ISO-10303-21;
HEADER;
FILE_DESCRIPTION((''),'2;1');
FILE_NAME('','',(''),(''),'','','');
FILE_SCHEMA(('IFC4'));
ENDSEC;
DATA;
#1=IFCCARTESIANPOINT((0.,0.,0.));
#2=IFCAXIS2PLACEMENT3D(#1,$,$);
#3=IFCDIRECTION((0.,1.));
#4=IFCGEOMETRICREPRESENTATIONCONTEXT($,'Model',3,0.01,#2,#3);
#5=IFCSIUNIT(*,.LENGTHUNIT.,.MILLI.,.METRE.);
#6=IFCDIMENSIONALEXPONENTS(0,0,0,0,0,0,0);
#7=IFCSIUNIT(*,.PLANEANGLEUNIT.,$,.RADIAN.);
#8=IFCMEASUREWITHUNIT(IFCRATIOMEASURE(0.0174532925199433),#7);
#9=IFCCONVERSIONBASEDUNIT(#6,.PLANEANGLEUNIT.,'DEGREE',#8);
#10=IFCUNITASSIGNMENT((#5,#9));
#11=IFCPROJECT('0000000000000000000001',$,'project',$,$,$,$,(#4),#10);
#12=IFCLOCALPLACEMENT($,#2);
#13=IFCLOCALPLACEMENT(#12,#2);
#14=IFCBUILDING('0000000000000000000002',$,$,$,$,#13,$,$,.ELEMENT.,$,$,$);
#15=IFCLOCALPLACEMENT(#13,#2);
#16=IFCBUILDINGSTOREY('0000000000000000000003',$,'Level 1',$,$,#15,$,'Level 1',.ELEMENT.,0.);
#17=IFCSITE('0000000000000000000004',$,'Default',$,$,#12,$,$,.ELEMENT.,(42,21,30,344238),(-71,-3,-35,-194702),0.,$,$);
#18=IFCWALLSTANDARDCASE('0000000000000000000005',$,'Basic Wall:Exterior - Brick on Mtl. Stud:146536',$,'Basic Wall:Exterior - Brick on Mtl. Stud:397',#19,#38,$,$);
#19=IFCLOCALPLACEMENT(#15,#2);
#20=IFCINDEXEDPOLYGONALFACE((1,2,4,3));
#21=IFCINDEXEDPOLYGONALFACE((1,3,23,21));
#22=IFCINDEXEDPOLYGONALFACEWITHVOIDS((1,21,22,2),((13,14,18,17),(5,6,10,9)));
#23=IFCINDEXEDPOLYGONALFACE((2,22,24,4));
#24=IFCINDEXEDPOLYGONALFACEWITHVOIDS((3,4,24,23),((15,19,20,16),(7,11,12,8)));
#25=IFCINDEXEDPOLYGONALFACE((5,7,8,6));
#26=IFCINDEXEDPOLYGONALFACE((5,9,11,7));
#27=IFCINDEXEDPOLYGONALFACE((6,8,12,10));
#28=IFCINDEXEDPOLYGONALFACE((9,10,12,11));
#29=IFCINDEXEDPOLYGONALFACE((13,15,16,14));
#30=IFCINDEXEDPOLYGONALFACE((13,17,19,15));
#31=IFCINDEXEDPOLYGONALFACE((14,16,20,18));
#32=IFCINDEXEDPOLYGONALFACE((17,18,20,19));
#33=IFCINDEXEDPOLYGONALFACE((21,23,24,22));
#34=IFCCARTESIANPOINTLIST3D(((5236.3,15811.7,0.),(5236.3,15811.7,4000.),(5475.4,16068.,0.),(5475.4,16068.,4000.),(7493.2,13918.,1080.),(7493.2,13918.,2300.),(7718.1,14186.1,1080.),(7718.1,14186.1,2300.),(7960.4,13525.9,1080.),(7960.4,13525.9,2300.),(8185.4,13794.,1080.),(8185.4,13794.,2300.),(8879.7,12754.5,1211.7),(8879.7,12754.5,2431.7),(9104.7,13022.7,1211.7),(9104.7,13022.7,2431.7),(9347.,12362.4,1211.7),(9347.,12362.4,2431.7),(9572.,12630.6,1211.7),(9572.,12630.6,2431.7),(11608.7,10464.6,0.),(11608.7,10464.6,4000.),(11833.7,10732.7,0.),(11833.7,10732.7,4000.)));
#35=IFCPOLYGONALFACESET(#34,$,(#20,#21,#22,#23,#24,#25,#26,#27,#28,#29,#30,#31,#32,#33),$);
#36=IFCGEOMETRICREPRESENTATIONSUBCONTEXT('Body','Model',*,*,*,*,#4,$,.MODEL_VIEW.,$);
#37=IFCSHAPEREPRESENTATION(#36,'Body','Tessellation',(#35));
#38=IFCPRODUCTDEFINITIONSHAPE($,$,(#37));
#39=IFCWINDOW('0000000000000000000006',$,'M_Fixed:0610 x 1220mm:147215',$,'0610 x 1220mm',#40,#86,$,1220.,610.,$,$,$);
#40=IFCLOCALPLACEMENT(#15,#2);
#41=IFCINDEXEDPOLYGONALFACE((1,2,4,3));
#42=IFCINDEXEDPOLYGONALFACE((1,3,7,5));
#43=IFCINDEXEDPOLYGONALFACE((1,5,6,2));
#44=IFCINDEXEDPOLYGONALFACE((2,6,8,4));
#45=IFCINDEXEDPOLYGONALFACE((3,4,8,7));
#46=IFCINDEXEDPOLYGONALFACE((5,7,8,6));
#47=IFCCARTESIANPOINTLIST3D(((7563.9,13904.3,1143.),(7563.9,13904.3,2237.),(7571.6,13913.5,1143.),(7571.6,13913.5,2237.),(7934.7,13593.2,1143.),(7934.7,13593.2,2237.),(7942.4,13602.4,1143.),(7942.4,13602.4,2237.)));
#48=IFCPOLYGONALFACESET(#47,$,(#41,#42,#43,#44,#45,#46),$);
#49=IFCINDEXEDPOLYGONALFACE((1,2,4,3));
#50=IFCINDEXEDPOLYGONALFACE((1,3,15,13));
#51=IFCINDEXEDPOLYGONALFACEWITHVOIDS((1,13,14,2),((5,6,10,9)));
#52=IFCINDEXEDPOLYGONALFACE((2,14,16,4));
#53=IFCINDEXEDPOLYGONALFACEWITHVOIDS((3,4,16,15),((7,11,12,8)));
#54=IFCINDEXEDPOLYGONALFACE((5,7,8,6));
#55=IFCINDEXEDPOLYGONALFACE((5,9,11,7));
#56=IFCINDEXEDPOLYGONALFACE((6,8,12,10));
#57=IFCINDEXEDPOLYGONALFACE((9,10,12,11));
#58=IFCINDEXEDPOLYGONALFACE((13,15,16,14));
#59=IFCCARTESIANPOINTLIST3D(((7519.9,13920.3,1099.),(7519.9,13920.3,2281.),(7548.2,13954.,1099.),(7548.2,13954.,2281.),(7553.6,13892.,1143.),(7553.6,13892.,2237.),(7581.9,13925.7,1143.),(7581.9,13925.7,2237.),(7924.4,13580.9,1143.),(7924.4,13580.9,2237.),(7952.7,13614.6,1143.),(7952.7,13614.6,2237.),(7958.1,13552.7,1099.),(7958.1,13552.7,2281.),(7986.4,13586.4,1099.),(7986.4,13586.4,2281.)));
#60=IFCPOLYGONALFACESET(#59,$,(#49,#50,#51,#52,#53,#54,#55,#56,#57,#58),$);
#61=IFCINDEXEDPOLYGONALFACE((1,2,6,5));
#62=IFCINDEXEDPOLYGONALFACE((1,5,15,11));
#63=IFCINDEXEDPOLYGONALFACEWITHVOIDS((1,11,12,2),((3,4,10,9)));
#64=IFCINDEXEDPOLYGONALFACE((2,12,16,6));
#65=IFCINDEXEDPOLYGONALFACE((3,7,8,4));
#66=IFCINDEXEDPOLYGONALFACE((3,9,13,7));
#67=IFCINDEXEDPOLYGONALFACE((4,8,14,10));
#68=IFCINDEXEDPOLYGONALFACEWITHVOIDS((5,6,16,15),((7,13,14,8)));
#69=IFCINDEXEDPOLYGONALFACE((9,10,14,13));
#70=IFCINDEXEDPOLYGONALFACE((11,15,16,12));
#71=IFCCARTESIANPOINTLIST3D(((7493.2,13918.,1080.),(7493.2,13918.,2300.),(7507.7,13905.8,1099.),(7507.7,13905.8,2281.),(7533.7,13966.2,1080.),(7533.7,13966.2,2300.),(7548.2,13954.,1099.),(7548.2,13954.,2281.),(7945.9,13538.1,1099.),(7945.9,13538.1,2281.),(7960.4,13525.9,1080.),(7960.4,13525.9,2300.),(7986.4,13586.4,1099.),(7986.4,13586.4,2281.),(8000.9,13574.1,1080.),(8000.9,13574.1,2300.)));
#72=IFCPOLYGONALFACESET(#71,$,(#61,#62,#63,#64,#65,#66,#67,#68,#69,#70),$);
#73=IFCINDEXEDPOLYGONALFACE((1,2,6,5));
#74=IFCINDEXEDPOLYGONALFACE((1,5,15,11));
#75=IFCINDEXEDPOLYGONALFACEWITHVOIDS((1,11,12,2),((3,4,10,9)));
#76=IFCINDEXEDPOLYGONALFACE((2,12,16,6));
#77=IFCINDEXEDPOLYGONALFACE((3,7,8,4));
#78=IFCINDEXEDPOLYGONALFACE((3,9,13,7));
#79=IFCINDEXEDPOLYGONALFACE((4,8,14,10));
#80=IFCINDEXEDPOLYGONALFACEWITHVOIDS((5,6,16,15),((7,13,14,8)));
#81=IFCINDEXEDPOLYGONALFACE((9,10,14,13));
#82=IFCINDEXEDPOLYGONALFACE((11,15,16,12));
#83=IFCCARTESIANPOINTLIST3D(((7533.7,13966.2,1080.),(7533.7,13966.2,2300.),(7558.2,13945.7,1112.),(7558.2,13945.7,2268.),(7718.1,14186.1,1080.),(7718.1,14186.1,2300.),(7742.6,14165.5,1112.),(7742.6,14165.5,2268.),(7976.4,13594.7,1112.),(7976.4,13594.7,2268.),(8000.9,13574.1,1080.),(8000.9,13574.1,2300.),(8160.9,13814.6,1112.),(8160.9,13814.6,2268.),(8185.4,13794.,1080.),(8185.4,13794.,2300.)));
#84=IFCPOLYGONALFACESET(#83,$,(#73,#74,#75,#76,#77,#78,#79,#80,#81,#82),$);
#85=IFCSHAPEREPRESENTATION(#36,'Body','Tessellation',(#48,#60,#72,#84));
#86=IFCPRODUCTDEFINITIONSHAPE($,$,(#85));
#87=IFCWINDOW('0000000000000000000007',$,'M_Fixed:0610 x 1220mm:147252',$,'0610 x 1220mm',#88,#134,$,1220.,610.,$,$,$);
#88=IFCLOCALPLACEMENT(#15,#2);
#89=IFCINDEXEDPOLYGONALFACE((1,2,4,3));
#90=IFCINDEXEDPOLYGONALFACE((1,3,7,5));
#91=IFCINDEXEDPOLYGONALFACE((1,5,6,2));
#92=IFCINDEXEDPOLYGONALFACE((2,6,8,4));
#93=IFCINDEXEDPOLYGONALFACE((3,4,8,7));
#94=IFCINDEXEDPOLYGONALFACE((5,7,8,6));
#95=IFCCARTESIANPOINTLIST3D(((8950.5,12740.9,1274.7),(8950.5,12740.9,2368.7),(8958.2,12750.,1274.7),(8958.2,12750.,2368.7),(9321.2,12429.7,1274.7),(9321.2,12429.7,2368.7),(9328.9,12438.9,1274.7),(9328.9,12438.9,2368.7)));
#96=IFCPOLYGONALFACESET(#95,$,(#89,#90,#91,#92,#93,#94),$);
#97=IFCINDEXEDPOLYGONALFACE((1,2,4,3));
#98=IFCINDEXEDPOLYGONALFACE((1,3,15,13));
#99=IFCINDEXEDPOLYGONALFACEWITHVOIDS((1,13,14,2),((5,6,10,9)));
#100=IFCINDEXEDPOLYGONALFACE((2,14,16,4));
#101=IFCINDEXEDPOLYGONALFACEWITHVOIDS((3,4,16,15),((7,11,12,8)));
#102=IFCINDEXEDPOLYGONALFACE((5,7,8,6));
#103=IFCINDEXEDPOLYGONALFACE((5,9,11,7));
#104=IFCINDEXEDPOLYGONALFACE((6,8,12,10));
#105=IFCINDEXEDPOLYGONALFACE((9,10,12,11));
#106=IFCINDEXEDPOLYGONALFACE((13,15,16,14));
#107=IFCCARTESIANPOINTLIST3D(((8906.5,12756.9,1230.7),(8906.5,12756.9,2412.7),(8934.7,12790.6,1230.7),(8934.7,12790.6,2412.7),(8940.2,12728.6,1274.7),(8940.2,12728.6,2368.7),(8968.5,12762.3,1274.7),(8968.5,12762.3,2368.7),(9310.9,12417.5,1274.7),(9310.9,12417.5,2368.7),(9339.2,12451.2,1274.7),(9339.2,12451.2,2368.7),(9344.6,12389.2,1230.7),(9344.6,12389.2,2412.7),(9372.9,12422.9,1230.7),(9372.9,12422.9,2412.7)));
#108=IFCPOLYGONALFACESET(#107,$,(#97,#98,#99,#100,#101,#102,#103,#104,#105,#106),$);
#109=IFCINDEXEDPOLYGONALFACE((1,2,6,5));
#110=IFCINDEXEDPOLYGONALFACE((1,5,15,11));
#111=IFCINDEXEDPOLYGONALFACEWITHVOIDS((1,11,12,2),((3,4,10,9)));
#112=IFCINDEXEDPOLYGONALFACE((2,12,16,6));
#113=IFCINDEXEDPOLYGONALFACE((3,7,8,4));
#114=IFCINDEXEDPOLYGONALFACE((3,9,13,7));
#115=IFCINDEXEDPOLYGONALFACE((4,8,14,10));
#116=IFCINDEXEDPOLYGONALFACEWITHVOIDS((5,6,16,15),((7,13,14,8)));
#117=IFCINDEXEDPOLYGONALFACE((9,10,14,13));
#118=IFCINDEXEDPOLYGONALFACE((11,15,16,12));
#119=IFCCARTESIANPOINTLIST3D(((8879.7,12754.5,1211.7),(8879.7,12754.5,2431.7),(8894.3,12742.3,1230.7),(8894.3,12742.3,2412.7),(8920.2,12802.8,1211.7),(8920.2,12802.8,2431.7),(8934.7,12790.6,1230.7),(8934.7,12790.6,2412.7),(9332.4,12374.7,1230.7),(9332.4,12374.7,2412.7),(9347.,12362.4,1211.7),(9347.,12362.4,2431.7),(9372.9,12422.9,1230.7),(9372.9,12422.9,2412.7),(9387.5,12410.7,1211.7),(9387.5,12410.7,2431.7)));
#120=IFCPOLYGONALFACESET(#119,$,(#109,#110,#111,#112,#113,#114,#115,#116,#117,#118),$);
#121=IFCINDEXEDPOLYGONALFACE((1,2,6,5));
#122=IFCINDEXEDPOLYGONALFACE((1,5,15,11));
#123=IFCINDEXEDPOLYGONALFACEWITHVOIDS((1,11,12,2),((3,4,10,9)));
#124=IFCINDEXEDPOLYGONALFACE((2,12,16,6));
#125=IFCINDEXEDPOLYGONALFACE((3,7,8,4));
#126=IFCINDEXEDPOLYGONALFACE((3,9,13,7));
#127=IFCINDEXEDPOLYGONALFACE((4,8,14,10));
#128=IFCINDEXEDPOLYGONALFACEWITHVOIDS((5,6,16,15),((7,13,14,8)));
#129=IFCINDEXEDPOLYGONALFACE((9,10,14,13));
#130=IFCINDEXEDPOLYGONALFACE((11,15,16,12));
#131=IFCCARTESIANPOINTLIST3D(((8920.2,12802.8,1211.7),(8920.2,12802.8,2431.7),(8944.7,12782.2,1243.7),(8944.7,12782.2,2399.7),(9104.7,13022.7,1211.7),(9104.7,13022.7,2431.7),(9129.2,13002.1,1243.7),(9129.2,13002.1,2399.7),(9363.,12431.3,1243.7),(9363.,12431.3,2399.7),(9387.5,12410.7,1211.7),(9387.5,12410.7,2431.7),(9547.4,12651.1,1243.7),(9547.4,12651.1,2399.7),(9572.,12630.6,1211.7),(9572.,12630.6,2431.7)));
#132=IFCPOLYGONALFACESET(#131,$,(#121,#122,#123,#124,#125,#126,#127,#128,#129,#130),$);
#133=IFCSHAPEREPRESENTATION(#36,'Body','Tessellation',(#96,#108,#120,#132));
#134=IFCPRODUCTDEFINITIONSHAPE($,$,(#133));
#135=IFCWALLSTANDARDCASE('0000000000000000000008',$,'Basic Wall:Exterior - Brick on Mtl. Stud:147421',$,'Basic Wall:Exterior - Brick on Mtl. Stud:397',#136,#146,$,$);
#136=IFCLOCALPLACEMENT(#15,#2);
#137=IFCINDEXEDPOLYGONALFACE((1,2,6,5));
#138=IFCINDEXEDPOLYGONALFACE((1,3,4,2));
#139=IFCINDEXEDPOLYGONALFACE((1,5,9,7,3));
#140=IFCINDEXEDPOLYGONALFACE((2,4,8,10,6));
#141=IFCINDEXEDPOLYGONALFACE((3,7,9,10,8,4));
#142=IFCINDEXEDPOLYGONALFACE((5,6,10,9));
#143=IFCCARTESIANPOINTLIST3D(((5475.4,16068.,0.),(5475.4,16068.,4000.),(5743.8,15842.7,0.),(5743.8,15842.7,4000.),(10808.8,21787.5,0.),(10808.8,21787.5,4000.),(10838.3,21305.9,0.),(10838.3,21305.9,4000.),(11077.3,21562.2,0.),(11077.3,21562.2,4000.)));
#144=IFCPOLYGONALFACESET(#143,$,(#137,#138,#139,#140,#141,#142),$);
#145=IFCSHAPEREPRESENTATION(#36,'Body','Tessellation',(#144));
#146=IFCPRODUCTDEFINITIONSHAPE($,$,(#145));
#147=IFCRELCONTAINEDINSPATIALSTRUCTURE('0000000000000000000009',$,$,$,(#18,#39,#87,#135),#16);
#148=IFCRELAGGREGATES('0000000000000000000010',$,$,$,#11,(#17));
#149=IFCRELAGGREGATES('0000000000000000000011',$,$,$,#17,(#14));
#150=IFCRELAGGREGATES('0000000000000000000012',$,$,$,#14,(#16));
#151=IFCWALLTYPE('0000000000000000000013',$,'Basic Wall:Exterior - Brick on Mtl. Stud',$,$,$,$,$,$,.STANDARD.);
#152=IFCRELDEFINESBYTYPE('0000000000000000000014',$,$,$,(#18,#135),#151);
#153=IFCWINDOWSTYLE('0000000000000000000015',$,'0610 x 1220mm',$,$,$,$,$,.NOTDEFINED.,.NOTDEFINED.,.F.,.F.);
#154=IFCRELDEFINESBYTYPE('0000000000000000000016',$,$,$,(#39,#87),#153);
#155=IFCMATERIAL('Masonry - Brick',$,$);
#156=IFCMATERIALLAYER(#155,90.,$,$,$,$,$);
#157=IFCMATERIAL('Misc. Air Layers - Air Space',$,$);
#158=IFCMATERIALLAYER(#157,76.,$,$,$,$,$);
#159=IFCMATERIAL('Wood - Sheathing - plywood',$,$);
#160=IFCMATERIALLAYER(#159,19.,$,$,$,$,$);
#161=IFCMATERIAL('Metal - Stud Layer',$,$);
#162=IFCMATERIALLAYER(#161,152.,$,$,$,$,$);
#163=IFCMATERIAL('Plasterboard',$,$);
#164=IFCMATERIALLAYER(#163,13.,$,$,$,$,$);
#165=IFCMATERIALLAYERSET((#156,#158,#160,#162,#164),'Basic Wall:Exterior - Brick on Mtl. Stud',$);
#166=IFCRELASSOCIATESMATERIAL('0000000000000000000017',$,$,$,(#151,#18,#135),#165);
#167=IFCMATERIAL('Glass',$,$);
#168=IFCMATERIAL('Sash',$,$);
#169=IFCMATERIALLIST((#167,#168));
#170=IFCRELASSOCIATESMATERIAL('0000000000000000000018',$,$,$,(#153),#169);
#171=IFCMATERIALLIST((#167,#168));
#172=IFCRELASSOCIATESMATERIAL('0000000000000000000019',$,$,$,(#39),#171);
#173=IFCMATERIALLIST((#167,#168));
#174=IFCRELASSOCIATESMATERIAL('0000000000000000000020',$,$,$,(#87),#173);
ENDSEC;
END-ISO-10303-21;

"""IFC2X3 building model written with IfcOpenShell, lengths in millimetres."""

from ifc_helpers import new_model, entity, si_unit, converted_unit, direction, frame, frame_2d, origin, place, context, subcontext, project, spatial, polyline, rectangle, outline, extrude, source, transform, mapped, material, material_list, layer, layer_set, layer_usage, type_object, type_shapes, element, fill, save


model = new_model("IFC2X3")

# Units and contexts
model_context = context("Model", 3, precision=0.01, world=origin(), true_north=direction((0.0, 1.0)))
body_context = subcontext(model_context, "Body", "Model", "MODEL_VIEW")
ifc_project = project(units=[si_unit("LENGTHUNIT", "METRE", prefix="MILLI"), converted_unit("PLANEANGLEUNIT", "DEGREE", entity("IfcRatioMeasure", 0.0174532925199433), si_unit("PLANEANGLEUNIT", "RADIAN"), dimensions=[0, 0, 0, 0, 0, 0, 0])], contexts=[model_context])

# Site, building, storey
site_placement = place(None, origin())
site = spatial("IfcSite", under=ifc_project, at=site_placement, Name="Default", CompositionType="ELEMENT", RefLatitude=(42, 21, 30, 344238), RefLongitude=(-71, -3, -35, -194702), RefElevation=0.0)
building_placement = place(site_placement, origin())
building = spatial("IfcBuilding", under=site, at=building_placement, CompositionType="ELEMENT")
storey_placement = place(building_placement, origin())
storey = spatial("IfcBuildingStorey", under=building, at=storey_placement, Name="Level 1", LongName="Level 1", CompositionType="ELEMENT", Elevation=0.0)

# Shared definitions
ifc_material_1 = material(Name="Masonry - Brick")
ifc_layer_1 = layer(ifc_material_1, 90.0)
ifc_material_2 = material(Name="Misc. Air Layers - Air Space")
ifc_layer_2 = layer(ifc_material_2, 76.0)
ifc_material_3 = material(Name="Wood - Sheathing - plywood")
ifc_layer_3 = layer(ifc_material_3, 19.0)
ifc_material_4 = material(Name="Metal - Stud Layer")
ifc_layer_4 = layer(ifc_material_4, 152.0)
ifc_material_5 = material(Name="Plasterboard")
ifc_layer_5 = layer(ifc_material_5, 13.0)
ifc_layer_set = layer_set([ifc_layer_1, ifc_layer_2, ifc_layer_3, ifc_layer_4, ifc_layer_5], Name="Basic Wall:Exterior - Brick on Mtl. Stud")
wall_type = type_object("IfcWallType", Name="Basic Wall:Exterior - Brick on Mtl. Stud", PredefinedType="STANDARD", material=ifc_layer_set)

# Wall, openings, windows
ifc_layer_usage_1 = layer_usage(ifc_layer_set, "AXIS2", "NEGATIVE", 175.0)
wall_1_placement = place(storey_placement, frame((11721.2, 10598.7, 0.0), z_axis=(0.0, 0.0, 1.0), x_axis=(-0.766044, 0.642788, 0.0)))
wall_1 = element("IfcWallStandardCase", 1, at=wall_1_placement, inside=storey, type_object=wall_type, material=ifc_layer_usage_1, Name="Basic Wall:Exterior - Brick on Mtl. Stud:146536", ObjectType="Basic Wall:Exterior - Brick on Mtl. Stud:397", context=body_context, shape_type="SweptSolid", body=[
    extrude(outline(polyline([(8300.2, -175.0), (8318.6, 175.0), (0.0, 175.0), (0.0, -175.0), (7949.8, -175.0), (8300.2, -175.0)])), origin(), (0.0, 0.0, 1.0), 4000.0),
])
opening_1_placement = place(wall_1_placement, frame((4762.5, -175.0, 1080.0)))
opening_1 = element("IfcOpeningElement", 2, at=opening_1_placement, cuts=wall_1, ObjectType="Opening", context=body_context, shape_type="SweptSolid", body=[
    extrude(rectangle(XDim=1220.0, YDim=610.0, at=frame_2d((610.0, 305.0), x_axis=(1.0, 0.0))), frame((0.0, 0.0, 0.0), z_axis=(0.0, 1.0, 0.0), x_axis=(0.0, 0.0, 1.0)), (0.0, 0.0, 1.0), 350.0),
])
opening_2_placement = place(wall_1_placement, frame((2952.5, -175.0, 1211.7)))
opening_2 = element("IfcOpeningElement", 3, at=opening_2_placement, cuts=wall_1, ObjectType="Opening", context=body_context, shape_type="SweptSolid", body=[
    extrude(rectangle(XDim=1220.0, YDim=610.0, at=frame_2d((610.0, 305.0), x_axis=(1.0, 0.0))), frame((0.0, 0.0, 0.0), z_axis=(0.0, 1.0, 0.0), x_axis=(0.0, 0.0, 1.0)), (0.0, 0.0, 1.0), 350.0),
])
ifc_material_6 = material(Name="Glass")
ifc_material_7 = material(Name="Sash")
ifc_material_list_1 = material_list([ifc_material_6, ifc_material_7])
ifc_material_list_2 = material_list([ifc_material_6, ifc_material_7])
window_style = type_object("IfcWindowStyle", Name="0610 x 1220mm", ConstructionType="NOTDEFINED", OperationType="NOTDEFINED", ParameterTakesPrecedence=False, Sizeable=False, material=ifc_material_list_2)
shared_shape_1 = source(origin(), body_context, "Body", "SweptSolid", [
    extrude(rectangle(XDim=12.0, YDim=484.0, at=frame_2d((0.0, 0.0), x_axis=(1.0, 0.0))), frame((305.0, 309.0, 63.0), z_axis=(0.0, 0.0, 1.0), x_axis=(0.0, -1.0, 0.0)), (0.0, 0.0, 1.0), 1094.0),
    extrude(outline(polyline([(-286.0, -591.0), (286.0, -591.0), (286.0, 591.0), (-286.0, 591.0), (-286.0, -591.0)]), holes=[polyline([(-242.0, -547.0), (-242.0, 547.0), (242.0, 547.0), (242.0, -547.0), (-242.0, -547.0)])]), frame((305.0, 287.0, 610.0), z_axis=(0.0, 1.0, 0.0), x_axis=(1.0, 0.0, 0.0)), (0.0, 0.0, 1.0), 44.0),
    extrude(outline(polyline([(-305.0, -610.0), (305.0, -610.0), (305.0, 610.0), (-305.0, 610.0), (-305.0, -610.0)]), holes=[polyline([(-286.0, -591.0), (-286.0, 591.0), (286.0, 591.0), (286.0, -591.0), (-286.0, -591.0)])]), frame((305.0, 287.0, 610.0), z_axis=(0.0, 1.0, 0.0), x_axis=(1.0, 0.0, 0.0)), (0.0, 0.0, 1.0), 63.0),
    extrude(outline(polyline([(-305.0, -610.0), (305.0, -610.0), (305.0, 610.0), (-305.0, 610.0), (-305.0, -610.0)]), holes=[polyline([(-273.0, -578.0), (-273.0, 578.0), (273.0, 578.0), (273.0, -578.0), (-273.0, -578.0)])]), frame((305.0, 0.0, 610.0), z_axis=(0.0, 1.0, 0.0), x_axis=(1.0, 0.0, 0.0)), (0.0, 0.0, 1.0), 287.0),
])
type_shapes(window_style, [shared_shape_1])
window_1_placement = place(opening_1_placement, origin())
window_1 = element("IfcWindow", 4, at=window_1_placement, inside=storey, type_object=window_style, material=ifc_material_list_1, Name="M_Fixed:0610 x 1220mm:147215", ObjectType="0610 x 1220mm", OverallHeight=1220.0, OverallWidth=610.0, context=body_context, shape_type="MappedRepresentation", body=[
    mapped(shared_shape_1, transform((0.0, 0.0, 0.0), scale=1.0)),
])
fill(opening_1, window_1)
ifc_material_list_3 = material_list([ifc_material_6, ifc_material_7])
window_2_placement = place(opening_2_placement, origin())
window_2 = element("IfcWindow", 5, at=window_2_placement, inside=storey, type_object=window_style, material=ifc_material_list_3, Name="M_Fixed:0610 x 1220mm:147252", ObjectType="0610 x 1220mm", OverallHeight=1220.0, OverallWidth=610.0, context=body_context, shape_type="MappedRepresentation", body=[
    mapped(shared_shape_1, transform((0.0, 0.0, 0.0), scale=1.0)),
])
fill(opening_2, window_2)

# Wall
ifc_layer_usage_2 = layer_usage(ifc_layer_set, "AXIS2", "NEGATIVE", 175.0)
wall_2_placement = place(storey_placement, frame((5603.3, 15948.7, 0.0), z_axis=(0.0, 0.0, 1.0), x_axis=(0.681998, 0.731354, 0.0)))
element("IfcWallStandardCase", 6, at=wall_2_placement, inside=storey, type_object=wall_type, material=ifc_layer_usage_2, Name="Basic Wall:Exterior - Brick on Mtl. Stud:147421", ObjectType="Basic Wall:Exterior - Brick on Mtl. Stud:397", context=body_context, shape_type="SweptSolid", body=[
    extrude(outline(polyline([(7838.7, -175.0), (7820.4, 175.0), (0.0, 175.0), (18.3, -175.0), (7488.2, -175.0), (7838.7, -175.0)])), origin(), (0.0, 0.0, 1.0), 4000.0),
])

save(model, "model.ifc")
